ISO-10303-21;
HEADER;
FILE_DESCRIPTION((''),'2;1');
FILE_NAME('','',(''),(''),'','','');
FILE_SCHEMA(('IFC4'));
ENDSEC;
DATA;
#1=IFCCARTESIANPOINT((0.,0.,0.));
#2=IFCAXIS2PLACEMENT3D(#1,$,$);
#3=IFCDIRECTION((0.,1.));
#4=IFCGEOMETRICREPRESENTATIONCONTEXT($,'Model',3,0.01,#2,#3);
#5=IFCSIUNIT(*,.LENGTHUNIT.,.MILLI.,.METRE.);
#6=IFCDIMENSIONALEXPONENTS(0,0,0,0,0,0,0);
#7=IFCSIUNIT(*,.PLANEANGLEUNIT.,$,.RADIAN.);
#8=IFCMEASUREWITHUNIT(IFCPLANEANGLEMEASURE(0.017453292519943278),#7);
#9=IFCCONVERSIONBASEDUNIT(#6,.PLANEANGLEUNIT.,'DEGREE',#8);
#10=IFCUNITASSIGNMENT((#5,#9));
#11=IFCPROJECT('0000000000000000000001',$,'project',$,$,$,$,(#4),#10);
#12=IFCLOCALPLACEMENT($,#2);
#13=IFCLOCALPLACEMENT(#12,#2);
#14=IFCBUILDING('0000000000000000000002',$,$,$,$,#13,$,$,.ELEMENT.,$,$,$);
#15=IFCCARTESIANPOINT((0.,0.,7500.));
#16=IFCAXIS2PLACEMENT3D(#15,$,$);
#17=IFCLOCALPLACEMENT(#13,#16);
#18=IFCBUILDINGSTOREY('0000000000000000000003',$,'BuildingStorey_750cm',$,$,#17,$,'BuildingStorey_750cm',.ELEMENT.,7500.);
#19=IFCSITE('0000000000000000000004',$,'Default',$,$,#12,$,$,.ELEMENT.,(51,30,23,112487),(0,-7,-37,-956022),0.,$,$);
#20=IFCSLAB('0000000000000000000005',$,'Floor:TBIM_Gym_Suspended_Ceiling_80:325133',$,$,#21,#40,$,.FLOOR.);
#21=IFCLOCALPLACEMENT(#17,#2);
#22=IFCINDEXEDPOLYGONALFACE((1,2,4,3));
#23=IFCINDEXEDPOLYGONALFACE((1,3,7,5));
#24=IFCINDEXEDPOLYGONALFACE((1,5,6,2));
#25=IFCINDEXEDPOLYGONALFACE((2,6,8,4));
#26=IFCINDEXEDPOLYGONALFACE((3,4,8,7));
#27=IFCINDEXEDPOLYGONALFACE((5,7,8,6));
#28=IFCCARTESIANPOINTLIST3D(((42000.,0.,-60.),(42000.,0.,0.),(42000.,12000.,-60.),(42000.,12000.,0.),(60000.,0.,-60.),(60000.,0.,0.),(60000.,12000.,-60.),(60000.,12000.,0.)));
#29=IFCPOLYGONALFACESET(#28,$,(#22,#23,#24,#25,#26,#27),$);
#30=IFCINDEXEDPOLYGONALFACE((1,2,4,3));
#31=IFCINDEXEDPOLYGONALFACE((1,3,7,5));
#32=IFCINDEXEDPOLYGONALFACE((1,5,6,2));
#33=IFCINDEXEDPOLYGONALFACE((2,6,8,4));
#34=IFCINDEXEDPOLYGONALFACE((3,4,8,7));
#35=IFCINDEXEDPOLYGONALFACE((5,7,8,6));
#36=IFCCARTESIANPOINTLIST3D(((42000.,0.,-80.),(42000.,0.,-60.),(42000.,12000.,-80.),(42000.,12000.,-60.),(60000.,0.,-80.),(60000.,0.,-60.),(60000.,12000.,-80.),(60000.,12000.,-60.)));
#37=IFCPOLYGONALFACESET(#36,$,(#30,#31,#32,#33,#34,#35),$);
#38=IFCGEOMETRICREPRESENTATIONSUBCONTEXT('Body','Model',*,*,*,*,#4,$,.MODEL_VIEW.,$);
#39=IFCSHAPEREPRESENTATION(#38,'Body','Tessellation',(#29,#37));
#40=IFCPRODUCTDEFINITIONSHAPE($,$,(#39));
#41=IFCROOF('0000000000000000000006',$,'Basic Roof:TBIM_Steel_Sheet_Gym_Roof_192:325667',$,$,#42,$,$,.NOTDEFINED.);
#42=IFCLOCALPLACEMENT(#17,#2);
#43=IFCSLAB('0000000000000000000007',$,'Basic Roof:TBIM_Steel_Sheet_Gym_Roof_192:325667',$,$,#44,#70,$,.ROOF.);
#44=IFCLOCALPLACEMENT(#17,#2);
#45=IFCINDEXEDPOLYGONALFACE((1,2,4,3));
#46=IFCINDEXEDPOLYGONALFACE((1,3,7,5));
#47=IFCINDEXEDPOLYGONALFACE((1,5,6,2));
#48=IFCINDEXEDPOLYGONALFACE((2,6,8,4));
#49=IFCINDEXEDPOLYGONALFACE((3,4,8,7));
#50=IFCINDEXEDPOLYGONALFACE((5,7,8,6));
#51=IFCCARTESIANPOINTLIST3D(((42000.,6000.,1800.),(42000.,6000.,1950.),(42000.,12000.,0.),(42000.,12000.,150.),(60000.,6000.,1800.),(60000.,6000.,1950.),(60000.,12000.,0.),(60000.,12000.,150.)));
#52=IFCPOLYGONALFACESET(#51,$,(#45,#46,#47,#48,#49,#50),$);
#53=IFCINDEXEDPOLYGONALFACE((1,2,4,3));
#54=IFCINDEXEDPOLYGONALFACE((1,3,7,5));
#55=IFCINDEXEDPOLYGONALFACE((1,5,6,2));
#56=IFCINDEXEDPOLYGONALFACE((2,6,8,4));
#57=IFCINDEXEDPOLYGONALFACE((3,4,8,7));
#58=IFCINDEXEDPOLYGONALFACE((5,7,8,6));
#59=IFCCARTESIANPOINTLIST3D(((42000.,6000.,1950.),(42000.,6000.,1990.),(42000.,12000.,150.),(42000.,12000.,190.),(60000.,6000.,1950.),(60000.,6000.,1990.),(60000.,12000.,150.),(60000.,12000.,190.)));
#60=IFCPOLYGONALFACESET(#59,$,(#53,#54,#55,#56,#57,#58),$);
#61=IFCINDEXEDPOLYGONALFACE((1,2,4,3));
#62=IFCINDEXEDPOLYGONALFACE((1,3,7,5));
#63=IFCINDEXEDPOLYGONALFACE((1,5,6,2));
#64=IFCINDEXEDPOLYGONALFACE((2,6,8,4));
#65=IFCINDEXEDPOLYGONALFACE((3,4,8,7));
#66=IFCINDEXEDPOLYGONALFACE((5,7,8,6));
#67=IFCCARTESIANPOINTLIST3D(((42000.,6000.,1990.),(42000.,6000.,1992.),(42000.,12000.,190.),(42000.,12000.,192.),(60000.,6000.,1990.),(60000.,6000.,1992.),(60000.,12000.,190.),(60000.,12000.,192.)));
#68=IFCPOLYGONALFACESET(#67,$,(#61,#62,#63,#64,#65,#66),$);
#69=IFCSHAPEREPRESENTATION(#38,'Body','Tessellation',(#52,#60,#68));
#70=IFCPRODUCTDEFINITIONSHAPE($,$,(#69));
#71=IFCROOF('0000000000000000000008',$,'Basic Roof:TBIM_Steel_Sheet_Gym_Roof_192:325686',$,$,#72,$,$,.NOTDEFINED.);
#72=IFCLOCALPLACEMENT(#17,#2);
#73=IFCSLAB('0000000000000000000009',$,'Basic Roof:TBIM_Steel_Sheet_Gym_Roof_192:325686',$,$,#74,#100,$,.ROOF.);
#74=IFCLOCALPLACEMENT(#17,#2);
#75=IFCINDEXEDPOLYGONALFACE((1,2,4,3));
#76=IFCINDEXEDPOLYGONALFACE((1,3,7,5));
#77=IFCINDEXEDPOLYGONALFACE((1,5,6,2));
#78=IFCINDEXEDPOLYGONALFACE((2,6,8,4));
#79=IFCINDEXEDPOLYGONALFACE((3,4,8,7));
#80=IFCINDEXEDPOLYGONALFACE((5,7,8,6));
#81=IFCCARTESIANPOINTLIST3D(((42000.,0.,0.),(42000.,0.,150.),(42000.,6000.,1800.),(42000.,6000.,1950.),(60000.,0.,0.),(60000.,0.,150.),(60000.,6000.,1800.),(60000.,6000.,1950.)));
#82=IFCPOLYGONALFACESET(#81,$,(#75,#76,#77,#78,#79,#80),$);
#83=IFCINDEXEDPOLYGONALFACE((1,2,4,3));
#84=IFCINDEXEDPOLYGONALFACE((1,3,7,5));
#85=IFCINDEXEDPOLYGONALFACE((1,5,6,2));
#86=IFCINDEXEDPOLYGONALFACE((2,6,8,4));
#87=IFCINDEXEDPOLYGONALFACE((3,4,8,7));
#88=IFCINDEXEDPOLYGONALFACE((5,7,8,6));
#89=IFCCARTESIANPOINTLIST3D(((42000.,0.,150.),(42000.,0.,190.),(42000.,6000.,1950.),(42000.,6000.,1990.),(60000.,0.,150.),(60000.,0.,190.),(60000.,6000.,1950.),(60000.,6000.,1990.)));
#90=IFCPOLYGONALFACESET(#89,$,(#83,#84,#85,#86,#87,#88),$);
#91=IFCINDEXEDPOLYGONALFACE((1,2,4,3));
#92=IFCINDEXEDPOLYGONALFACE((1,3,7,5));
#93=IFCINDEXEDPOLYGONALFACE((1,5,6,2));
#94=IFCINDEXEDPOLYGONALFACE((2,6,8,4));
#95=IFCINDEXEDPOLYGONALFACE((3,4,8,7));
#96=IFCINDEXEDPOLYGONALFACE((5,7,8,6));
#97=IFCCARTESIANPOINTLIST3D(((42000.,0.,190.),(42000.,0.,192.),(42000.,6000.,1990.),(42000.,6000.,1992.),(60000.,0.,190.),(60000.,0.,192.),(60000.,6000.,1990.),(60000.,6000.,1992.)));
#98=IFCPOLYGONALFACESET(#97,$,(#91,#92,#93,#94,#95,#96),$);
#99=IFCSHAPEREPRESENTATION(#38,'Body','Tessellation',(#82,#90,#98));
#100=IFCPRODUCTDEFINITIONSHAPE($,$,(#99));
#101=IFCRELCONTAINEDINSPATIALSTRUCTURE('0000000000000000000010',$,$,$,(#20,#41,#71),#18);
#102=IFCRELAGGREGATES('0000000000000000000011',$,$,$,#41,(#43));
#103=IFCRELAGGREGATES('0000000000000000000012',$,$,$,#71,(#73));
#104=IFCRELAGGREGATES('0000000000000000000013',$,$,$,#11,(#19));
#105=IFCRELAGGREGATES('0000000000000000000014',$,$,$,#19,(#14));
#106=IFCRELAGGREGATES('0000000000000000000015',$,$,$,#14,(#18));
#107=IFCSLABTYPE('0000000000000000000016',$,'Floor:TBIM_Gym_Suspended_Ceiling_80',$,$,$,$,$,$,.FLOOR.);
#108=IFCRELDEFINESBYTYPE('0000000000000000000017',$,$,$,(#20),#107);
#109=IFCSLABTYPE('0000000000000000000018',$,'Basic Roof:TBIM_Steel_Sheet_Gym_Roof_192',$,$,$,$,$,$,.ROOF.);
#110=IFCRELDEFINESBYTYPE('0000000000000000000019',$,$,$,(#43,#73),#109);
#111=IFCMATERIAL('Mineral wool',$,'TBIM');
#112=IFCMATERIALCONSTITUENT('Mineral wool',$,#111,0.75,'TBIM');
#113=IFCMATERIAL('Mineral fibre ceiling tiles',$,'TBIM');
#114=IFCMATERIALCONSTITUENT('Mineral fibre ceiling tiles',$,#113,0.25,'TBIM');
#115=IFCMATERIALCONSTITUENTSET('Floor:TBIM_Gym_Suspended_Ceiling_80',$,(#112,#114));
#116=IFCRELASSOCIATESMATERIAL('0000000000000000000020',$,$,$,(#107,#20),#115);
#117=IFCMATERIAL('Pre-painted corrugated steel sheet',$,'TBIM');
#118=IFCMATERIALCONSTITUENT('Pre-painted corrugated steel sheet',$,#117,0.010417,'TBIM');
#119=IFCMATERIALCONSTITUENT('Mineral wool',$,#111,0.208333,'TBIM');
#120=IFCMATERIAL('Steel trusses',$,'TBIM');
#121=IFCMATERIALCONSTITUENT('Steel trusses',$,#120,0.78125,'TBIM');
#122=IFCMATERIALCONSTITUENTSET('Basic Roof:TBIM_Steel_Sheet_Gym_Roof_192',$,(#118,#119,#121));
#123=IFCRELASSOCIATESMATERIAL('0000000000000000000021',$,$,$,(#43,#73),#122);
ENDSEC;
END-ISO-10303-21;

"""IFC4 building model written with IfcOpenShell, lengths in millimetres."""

from ifc_helpers import new_model, entity, si_unit, converted_unit, direction, frame, origin, place, context, subcontext, project, spatial, indexed_curve, outline, extrude, material, constituent, constituent_set, type_object, element, aggregate, save


model = new_model("IFC4")

# Units and contexts
model_context = context("Model", 3, precision=0.01, world=origin(), true_north=direction((0.0, 1.0)))
body_context = subcontext(model_context, "Body", "Model", "MODEL_VIEW")
ifc_project = project(units=[si_unit("LENGTHUNIT", "METRE", prefix="MILLI"), converted_unit("PLANEANGLEUNIT", "DEGREE", entity("IfcPlaneAngleMeasure", 0.017453292519943278), si_unit("PLANEANGLEUNIT", "RADIAN"), dimensions=[0, 0, 0, 0, 0, 0, 0])], contexts=[model_context])

# Site, building, storey
site_placement = place(None, origin())
site = spatial("IfcSite", under=ifc_project, at=site_placement, Name="Default", CompositionType="ELEMENT", RefLatitude=(51, 30, 23, 112487), RefLongitude=(0, -7, -37, -956022), RefElevation=0.0)
building_placement = place(site_placement, origin())
building = spatial("IfcBuilding", under=site, at=building_placement, CompositionType="ELEMENT")
storey_placement = place(building_placement, frame((0.0, 0.0, 7500.0)))
storey = spatial("IfcBuildingStorey", under=building, at=storey_placement, Name="BuildingStorey_750cm", LongName="BuildingStorey_750cm", CompositionType="ELEMENT", Elevation=7500.0)

# Slab
ifc_material_1 = material(Name="Mineral wool", Category="TBIM")
ifc_constituent_1 = constituent(ifc_material_1, Name="Mineral wool", Category="TBIM", fraction=0.75)
ifc_material_2 = material(Name="Mineral fibre ceiling tiles", Category="TBIM")
ifc_constituent_2 = constituent(ifc_material_2, Name="Mineral fibre ceiling tiles", Category="TBIM", fraction=0.25)
ifc_constituent_set_1 = constituent_set(constituents=[ifc_constituent_1, ifc_constituent_2], Name="Floor:TBIM_Gym_Suspended_Ceiling_80")
slab_type_1 = type_object("IfcSlabType", Name="Floor:TBIM_Gym_Suspended_Ceiling_80", PredefinedType="FLOOR", material=ifc_constituent_set_1)
slab_1_placement = place(storey_placement, origin())
element("IfcSlab", 1, at=slab_1_placement, inside=storey, type_object=slab_type_1, material=ifc_constituent_set_1, Name="Floor:TBIM_Gym_Suspended_Ceiling_80:325133", PredefinedType="FLOOR", context=body_context, shape_type="SweptSolid", body=[
    extrude(outline(indexed_curve([(-9000.0, -6000.0), (9000.0, -6000.0), (9000.0, 6000.0), (-9000.0, 6000.0), (-9000.0, -6000.0)], self_intersect=False)), frame((51000.0, 6000.0, -60.0), z_axis=(0.0, 0.0, 1.0), x_axis=(-1.0, 0.0, 0.0)), (0.0, 0.0, 1.0), 60.0),
    extrude(outline(indexed_curve([(-9000.0, -6000.0), (9000.0, -6000.0), (9000.0, 6000.0), (-9000.0, 6000.0), (-9000.0, -6000.0)], self_intersect=False)), frame((51000.0, 6000.0, -80.0), z_axis=(0.0, 0.0, 1.0), x_axis=(-1.0, 0.0, 0.0)), (0.0, 0.0, 1.0), 20.0),
])

# Roofs, slabs
roof_1_placement = place(storey_placement, frame((42000.0, 6000.0, 0.0)))
roof_1 = element("IfcRoof", 2, at=roof_1_placement, inside=storey, Name="Basic Roof:TBIM_Steel_Sheet_Gym_Roof_192:325667", PredefinedType="NOTDEFINED")
ifc_material_3 = material(Name="Pre-painted corrugated steel sheet", Category="TBIM")
ifc_constituent_3 = constituent(ifc_material_3, Name="Pre-painted corrugated steel sheet", Category="TBIM", fraction=0.010417)
ifc_constituent_4 = constituent(ifc_material_1, Name="Mineral wool", Category="TBIM", fraction=0.208333)
ifc_material_4 = material(Name="Steel trusses", Category="TBIM")
ifc_constituent_5 = constituent(ifc_material_4, Name="Steel trusses", Category="TBIM", fraction=0.78125)
ifc_constituent_set_2 = constituent_set(constituents=[ifc_constituent_3, ifc_constituent_4, ifc_constituent_5], Name="Basic Roof:TBIM_Steel_Sheet_Gym_Roof_192")
slab_type_2 = type_object("IfcSlabType", Name="Basic Roof:TBIM_Steel_Sheet_Gym_Roof_192", PredefinedType="ROOF")
slab_2_placement = place(roof_1_placement, origin())
slab_2 = element("IfcSlab", 3, at=slab_2_placement, type_object=slab_type_2, material=ifc_constituent_set_2, Name="Basic Roof:TBIM_Steel_Sheet_Gym_Roof_192:325667", PredefinedType="ROOF", context=body_context, shape_type="SweptSolid", body=[
    extrude(outline(indexed_curve([(-9000.0, -3132.1), (9000.0, -3132.1), (9000.0, 3132.1), (-9000.0, 3132.1), (-9000.0, -3132.1)], self_intersect=False)), frame((9000.0, 3000.0, 900.0), z_axis=(0.0, 0.287348, 0.957826), x_axis=(1.0, 0.0, 0.0)), (0.0, -0.287348, 0.957826), 150.0),
    extrude(outline(indexed_curve([(-9000.0, -3132.1), (9000.0, -3132.1), (9000.0, 3132.1), (-9000.0, 3132.1), (-9000.0, -3132.1)], self_intersect=False)), frame((9000.0, 3000.0, 1050.0), z_axis=(0.0, 0.287348, 0.957826), x_axis=(1.0, 0.0, 0.0)), (0.0, -0.287348, 0.957826), 40.0),
    extrude(outline(indexed_curve([(-9000.0, -3132.1), (9000.0, -3132.1), (9000.0, 3132.1), (-9000.0, 3132.1), (-9000.0, -3132.1)], self_intersect=False)), frame((9000.0, 3000.0, 1090.0), z_axis=(0.0, 0.287348, 0.957826), x_axis=(1.0, 0.0, 0.0)), (0.0, -0.287348, 0.957826), 2.0),
])
aggregate(roof_1, [slab_2])
roof_2_placement = place(storey_placement, frame((42000.0, 0.0, 0.0)))
roof_2 = element("IfcRoof", 4, at=roof_2_placement, inside=storey, Name="Basic Roof:TBIM_Steel_Sheet_Gym_Roof_192:325686", PredefinedType="NOTDEFINED")
slab_3_placement = place(roof_2_placement, origin())
slab_3 = element("IfcSlab", 5, at=slab_3_placement, type_object=slab_type_2, material=ifc_constituent_set_2, Name="Basic Roof:TBIM_Steel_Sheet_Gym_Roof_192:325686", PredefinedType="ROOF", context=body_context, shape_type="SweptSolid", body=[
    extrude(outline(indexed_curve([(9000.0, 3132.1), (-9000.0, 3132.1), (-9000.0, -3132.1), (9000.0, -3132.1), (9000.0, 3132.1)], self_intersect=False)), frame((9000.0, 3000.0, 900.0), z_axis=(0.0, -0.287348, 0.957826), x_axis=(1.0, 0.0, 0.0)), (0.0, 0.287348, 0.957826), 150.0),
    extrude(outline(indexed_curve([(9000.0, 3132.1), (-9000.0, 3132.1), (-9000.0, -3132.1), (9000.0, -3132.1), (9000.0, 3132.1)], self_intersect=False)), frame((9000.0, 3000.0, 1050.0), z_axis=(0.0, -0.287348, 0.957826), x_axis=(1.0, 0.0, 0.0)), (0.0, 0.287348, 0.957826), 40.0),
    extrude(outline(indexed_curve([(9000.0, 3132.1), (-9000.0, 3132.1), (-9000.0, -3132.1), (9000.0, -3132.1), (9000.0, 3132.1)], self_intersect=False)), frame((9000.0, 3000.0, 1090.0), z_axis=(0.0, -0.287348, 0.957826), x_axis=(1.0, 0.0, 0.0)), (0.0, 0.287348, 0.957826), 2.0),
])
aggregate(roof_2, [slab_3])

save(model, "model.ifc")
